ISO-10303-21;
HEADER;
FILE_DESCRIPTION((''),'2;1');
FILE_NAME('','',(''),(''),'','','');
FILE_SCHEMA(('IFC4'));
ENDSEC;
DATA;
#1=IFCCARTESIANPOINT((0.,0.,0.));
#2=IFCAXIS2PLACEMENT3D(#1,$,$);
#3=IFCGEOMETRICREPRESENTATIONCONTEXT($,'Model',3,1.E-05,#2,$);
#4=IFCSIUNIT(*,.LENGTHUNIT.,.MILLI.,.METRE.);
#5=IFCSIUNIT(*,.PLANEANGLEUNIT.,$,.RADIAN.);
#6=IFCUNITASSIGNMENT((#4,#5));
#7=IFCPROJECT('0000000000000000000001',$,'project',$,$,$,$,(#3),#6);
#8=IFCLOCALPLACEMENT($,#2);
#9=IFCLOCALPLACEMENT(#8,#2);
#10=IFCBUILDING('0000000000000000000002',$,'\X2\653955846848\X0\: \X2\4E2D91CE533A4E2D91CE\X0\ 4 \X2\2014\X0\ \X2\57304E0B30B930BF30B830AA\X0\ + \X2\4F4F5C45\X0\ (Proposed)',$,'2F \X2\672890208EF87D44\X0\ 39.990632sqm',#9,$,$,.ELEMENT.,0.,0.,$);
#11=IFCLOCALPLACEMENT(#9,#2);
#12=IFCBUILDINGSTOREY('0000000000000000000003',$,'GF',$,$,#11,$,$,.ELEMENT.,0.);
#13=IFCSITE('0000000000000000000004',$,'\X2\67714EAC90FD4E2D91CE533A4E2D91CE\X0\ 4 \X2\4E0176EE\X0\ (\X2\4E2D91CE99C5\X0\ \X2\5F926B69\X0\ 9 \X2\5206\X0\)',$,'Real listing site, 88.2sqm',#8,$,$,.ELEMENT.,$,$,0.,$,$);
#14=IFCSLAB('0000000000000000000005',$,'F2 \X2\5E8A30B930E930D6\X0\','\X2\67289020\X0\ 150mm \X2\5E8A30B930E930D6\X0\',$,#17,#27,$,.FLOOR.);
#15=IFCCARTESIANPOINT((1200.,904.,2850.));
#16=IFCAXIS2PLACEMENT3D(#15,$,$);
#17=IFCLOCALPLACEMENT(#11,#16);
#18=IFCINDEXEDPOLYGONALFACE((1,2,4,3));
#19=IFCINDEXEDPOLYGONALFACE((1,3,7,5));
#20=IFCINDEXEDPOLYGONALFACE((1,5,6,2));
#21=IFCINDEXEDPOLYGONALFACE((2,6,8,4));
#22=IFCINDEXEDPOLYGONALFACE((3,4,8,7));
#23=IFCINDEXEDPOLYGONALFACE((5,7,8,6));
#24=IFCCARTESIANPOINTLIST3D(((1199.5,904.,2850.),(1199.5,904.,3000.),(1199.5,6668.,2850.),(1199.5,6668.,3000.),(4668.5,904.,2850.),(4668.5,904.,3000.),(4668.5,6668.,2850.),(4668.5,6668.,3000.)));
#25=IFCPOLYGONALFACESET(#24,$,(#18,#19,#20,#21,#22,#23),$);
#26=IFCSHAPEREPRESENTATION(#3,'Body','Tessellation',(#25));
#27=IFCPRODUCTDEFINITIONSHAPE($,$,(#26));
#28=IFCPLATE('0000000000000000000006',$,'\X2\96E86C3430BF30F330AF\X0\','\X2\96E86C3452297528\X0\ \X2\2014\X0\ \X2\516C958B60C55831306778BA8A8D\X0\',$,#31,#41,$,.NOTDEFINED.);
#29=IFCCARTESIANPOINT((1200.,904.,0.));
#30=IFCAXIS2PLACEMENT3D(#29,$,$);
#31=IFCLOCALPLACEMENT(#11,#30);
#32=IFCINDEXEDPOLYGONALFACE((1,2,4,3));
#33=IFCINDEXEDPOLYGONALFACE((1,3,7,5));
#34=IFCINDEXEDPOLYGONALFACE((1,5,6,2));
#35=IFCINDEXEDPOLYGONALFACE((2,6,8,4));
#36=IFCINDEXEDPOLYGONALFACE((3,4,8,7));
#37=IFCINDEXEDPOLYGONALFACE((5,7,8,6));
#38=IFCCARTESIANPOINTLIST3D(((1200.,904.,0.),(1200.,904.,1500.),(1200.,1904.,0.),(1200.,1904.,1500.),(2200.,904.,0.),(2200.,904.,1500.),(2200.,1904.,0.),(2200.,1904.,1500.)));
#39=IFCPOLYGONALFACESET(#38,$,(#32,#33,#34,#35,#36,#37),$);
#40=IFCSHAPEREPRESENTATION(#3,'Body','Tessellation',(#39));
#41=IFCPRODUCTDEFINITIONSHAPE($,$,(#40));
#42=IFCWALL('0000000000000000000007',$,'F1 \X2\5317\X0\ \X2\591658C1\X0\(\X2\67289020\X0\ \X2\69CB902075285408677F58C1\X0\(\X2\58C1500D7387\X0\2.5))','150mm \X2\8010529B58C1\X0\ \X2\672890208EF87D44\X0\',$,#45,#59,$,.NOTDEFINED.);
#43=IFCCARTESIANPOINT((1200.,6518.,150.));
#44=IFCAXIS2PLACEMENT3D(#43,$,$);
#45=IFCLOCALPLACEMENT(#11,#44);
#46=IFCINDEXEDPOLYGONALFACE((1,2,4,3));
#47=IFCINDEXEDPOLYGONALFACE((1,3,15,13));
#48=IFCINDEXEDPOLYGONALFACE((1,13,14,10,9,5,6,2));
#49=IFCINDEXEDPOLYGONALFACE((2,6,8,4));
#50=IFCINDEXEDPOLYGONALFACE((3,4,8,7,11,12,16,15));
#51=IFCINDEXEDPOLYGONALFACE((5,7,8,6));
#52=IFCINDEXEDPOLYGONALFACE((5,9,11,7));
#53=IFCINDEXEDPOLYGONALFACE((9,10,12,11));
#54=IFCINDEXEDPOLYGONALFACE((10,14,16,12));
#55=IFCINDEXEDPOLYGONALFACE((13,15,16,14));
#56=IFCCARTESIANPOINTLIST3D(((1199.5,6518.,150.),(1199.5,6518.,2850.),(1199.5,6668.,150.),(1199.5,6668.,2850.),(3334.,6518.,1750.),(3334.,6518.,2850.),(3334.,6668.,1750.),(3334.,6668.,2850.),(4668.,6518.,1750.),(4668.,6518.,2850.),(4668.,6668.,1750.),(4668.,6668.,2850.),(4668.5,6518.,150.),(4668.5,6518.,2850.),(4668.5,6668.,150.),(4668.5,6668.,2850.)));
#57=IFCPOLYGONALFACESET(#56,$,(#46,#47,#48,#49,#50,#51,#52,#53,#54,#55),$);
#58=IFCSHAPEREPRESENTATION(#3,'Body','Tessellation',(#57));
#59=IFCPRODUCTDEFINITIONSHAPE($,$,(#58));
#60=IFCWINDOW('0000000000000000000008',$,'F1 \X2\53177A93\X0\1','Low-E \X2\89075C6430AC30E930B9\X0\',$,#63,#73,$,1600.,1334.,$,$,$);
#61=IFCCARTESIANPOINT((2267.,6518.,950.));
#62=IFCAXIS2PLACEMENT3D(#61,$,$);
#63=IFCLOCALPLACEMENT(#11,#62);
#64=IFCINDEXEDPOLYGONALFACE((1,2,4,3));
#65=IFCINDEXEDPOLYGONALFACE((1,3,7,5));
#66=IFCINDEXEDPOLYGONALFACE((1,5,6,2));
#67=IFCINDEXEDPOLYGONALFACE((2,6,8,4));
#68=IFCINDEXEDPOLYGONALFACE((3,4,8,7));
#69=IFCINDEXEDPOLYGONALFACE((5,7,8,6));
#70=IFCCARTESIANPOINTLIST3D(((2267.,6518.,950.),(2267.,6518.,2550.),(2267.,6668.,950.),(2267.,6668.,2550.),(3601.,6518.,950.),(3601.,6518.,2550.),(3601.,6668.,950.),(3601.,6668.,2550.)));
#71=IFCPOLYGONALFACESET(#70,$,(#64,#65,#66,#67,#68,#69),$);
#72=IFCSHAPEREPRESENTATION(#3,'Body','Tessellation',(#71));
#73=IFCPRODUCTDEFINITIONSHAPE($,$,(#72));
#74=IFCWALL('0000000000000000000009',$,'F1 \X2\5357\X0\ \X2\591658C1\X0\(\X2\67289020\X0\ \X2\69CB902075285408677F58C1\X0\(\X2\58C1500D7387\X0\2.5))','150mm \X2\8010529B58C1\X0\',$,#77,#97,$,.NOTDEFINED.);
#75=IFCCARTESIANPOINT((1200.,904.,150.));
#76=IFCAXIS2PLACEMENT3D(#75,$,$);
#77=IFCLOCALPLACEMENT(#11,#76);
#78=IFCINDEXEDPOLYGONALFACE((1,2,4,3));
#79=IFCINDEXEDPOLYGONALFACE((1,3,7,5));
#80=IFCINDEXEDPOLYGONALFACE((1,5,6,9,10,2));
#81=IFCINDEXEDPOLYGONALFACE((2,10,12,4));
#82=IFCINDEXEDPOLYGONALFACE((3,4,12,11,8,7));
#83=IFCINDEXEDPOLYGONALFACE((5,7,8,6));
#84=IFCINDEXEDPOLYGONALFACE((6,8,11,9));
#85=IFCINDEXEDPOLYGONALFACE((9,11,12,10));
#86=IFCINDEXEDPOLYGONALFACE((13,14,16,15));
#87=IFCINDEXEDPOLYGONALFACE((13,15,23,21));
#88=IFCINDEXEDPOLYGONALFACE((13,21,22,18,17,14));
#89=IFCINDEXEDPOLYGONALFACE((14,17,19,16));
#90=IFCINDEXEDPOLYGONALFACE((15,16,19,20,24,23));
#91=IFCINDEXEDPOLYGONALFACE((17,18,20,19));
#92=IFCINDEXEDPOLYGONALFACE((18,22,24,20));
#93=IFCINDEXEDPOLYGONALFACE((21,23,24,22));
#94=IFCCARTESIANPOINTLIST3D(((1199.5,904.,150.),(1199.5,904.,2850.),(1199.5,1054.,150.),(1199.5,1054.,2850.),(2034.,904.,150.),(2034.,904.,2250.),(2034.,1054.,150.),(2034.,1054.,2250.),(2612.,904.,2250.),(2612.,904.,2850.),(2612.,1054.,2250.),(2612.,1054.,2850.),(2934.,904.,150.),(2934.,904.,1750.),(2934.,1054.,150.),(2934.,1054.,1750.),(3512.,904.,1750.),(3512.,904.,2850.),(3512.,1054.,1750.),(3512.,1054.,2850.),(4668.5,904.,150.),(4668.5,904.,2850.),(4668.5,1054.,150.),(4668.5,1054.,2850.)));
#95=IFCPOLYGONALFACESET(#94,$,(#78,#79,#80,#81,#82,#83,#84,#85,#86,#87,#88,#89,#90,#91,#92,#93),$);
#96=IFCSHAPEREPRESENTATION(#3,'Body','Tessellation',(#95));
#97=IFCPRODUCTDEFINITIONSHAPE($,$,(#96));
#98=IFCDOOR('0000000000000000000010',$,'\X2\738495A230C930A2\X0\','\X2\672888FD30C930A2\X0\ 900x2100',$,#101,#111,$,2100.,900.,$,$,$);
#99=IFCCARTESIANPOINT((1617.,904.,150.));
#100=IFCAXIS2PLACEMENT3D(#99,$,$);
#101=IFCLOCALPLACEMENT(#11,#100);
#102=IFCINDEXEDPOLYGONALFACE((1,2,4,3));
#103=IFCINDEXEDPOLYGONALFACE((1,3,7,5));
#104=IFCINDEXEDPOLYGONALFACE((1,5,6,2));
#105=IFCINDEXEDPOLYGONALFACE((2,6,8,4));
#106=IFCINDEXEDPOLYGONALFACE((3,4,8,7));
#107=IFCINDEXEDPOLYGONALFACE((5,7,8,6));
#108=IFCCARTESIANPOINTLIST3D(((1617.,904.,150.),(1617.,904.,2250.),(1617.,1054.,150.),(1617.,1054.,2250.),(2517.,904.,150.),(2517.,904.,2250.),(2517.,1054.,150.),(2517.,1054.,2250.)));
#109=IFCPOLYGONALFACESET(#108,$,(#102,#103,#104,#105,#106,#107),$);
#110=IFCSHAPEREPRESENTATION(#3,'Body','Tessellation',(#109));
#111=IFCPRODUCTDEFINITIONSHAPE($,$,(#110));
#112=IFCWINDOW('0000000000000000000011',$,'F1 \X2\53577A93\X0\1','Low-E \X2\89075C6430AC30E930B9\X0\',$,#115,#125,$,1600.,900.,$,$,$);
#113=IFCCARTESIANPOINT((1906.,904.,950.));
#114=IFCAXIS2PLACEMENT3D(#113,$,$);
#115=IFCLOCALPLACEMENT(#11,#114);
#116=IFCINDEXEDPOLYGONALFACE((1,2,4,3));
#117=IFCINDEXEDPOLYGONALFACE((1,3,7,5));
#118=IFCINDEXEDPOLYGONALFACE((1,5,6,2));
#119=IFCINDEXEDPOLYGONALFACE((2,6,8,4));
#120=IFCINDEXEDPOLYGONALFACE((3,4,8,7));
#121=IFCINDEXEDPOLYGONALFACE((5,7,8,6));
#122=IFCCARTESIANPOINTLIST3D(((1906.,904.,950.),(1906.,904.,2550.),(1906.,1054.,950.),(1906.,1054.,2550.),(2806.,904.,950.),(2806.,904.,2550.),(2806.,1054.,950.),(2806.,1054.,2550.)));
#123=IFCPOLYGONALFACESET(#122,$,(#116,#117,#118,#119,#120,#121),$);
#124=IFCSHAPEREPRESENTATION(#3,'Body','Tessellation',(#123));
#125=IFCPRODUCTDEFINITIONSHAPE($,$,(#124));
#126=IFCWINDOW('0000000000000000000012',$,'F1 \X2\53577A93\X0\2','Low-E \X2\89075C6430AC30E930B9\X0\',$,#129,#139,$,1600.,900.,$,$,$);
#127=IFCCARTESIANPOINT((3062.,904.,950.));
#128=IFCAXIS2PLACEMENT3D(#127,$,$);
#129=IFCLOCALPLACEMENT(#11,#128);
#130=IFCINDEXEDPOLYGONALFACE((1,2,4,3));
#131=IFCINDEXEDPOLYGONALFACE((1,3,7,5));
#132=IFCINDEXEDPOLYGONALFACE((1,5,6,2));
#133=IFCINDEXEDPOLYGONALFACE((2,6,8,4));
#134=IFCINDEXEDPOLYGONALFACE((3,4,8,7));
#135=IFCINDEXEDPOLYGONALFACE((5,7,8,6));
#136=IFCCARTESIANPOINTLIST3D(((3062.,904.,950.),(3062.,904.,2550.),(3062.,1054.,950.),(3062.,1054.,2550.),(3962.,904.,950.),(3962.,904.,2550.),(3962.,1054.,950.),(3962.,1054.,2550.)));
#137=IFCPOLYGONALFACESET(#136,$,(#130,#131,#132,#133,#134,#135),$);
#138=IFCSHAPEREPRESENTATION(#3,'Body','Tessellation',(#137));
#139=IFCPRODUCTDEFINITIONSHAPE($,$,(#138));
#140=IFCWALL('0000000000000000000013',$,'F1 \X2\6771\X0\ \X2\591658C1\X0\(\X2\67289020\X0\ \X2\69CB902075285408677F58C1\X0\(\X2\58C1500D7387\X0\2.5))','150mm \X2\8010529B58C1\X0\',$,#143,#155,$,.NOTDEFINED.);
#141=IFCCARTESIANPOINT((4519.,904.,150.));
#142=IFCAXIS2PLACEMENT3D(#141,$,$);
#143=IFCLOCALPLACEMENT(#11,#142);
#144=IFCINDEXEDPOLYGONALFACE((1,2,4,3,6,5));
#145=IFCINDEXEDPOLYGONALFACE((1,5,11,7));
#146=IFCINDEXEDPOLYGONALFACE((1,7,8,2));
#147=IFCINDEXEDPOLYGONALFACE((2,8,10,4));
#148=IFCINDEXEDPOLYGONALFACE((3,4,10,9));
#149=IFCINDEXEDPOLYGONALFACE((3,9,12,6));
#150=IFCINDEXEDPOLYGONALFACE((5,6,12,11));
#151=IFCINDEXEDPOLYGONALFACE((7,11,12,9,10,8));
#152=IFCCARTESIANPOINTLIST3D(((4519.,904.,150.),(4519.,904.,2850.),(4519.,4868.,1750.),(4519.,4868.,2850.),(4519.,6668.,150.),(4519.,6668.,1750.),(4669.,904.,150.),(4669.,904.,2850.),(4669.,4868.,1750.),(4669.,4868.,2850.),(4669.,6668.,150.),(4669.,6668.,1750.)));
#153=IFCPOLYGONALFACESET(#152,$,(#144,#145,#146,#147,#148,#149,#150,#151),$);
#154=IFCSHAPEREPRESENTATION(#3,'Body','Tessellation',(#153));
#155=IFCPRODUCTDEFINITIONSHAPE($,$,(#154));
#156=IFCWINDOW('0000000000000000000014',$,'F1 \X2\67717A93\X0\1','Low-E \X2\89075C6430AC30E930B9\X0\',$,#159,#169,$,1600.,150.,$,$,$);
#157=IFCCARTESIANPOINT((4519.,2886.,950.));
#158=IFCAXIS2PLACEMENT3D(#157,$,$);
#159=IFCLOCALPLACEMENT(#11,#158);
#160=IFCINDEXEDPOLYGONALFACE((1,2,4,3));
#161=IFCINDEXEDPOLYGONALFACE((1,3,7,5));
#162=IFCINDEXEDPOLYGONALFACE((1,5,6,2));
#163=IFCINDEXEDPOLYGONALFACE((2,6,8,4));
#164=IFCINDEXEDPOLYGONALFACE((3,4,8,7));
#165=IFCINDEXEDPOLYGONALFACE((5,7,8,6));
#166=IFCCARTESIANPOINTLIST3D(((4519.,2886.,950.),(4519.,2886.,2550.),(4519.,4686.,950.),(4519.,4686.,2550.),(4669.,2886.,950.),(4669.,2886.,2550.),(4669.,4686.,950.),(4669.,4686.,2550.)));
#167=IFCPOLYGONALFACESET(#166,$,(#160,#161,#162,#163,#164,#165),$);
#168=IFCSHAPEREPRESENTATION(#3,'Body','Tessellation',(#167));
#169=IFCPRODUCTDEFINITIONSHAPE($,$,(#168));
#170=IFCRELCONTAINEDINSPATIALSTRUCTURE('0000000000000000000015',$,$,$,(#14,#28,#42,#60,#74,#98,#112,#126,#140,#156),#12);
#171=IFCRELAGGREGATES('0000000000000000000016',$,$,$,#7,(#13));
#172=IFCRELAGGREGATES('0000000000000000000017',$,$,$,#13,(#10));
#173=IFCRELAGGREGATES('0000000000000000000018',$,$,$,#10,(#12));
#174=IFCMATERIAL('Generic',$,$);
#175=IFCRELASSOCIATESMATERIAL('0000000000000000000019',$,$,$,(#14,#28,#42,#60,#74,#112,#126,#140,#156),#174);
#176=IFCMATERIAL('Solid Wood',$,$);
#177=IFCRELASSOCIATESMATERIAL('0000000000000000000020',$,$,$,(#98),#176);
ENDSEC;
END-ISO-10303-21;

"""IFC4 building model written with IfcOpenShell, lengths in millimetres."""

from ifc_helpers import new_model, si_unit, frame, frame_2d, origin, place, context, project, spatial, rectangle, extrude, material, element, fill, save


model = new_model("IFC4")

# Units and contexts
model_context = context("Model", 3, precision=1e-05, world=origin())
ifc_project = project(units=[si_unit("LENGTHUNIT", "METRE", prefix="MILLI"), si_unit("PLANEANGLEUNIT", "RADIAN")], contexts=[model_context])

# Site, building, storey
site_placement = place(None, origin())
site = spatial("IfcSite", under=ifc_project, at=site_placement, Name="東京都中野区中野 4 丁目 (中野駅 徒歩 9 分)", ObjectType="Real listing site, 88.2sqm", CompositionType="ELEMENT", RefElevation=0.0)
building_placement = place(site_placement, origin())
building = spatial("IfcBuilding", under=site, at=building_placement, Name="改善案: 中野区中野 4 — 地下スタジオ + 住居 (Proposed)", ObjectType="2F 木造軸組 39.990632sqm", CompositionType="ELEMENT", ElevationOfRefHeight=0.0, ElevationOfTerrain=0.0)
storey_placement = place(building_placement, origin())
storey = spatial("IfcBuildingStorey", under=building, at=storey_placement, Name="GF", CompositionType="ELEMENT", Elevation=0.0)

# Slab
ifc_material_1 = material(Name="Generic")
slab_1_placement = place(storey_placement, frame((1200.0, 904.0, 2850.0)))
element("IfcSlab", 1, at=slab_1_placement, inside=storey, material=ifc_material_1, Name="F2 床スラブ", Description="木造 150mm 床スラブ", PredefinedType="FLOOR", context=model_context, shape_type="SweptSolid", body=[
    extrude(rectangle(XDim=3469.0, YDim=5764.0, at=frame_2d((1734.0, 2882.0))), frame((1200.0, 904.0, 2850.0)), (0.0, 0.0, 1.0), 150.0),
])

# Plate
plate_placement = place(storey_placement, frame((1200.0, 904.0, 0.0)))
element("IfcPlate", 2, at=plate_placement, inside=storey, material=ifc_material_1, Name="雨水タンク", Description="雨水利用 — 公開情報で確認", PredefinedType="NOTDEFINED", context=model_context, shape_type="SweptSolid", body=[
    extrude(rectangle(XDim=1000.0, YDim=1000.0, at=frame_2d((500.0, 500.0))), frame((1200.0, 904.0, 0.0)), (0.0, 0.0, 1.0), 1500.0),
])

# Wall, opening, window
wall_1_placement = place(storey_placement, frame((1200.0, 6518.0, 150.0)))
wall_1 = element("IfcWall", 3, at=wall_1_placement, inside=storey, material=ifc_material_1, Name="F1 北 外壁(木造 構造用合板壁(壁倍率2.5))", Description="150mm 耐力壁 木造軸組", PredefinedType="NOTDEFINED", context=model_context, shape_type="SweptSolid", body=[
    extrude(rectangle(XDim=3469.0, YDim=150.0, at=frame_2d((1734.0, 75.0))), frame((1200.0, 6518.0, 150.0)), (0.0, 0.0, 1.0), 2700.0),
])
opening_1_placement = place(storey_placement, frame((2267.0, 6518.0, 950.0)))
opening_1 = element("IfcOpeningElement", 4, at=opening_1_placement, cuts=wall_1, PredefinedType="NOTDEFINED", context=model_context, shape_type="SweptSolid", body=[
    extrude(rectangle(XDim=1334.0, YDim=150.0, at=frame_2d((667.0, 75.0))), frame((2267.0, 6518.0, 950.0)), (0.0, 0.0, 1.0), 1600.0),
])
window_1_placement = place(storey_placement, frame((2267.0, 6518.0, 950.0)))
window_1 = element("IfcWindow", 5, at=window_1_placement, inside=storey, material=ifc_material_1, Name="F1 北窓1", Description="Low-E 複層ガラス", OverallHeight=1600.0, OverallWidth=1334.0, context=model_context, shape_type="SweptSolid", body=[
    extrude(rectangle(XDim=1334.0, YDim=150.0, at=frame_2d((667.0, 75.0))), frame((2267.0, 6518.0, 950.0)), (0.0, 0.0, 1.0), 1600.0),
])
fill(opening_1, window_1)

# Wall, openings, door, windows
wall_2_placement = place(storey_placement, frame((1200.0, 904.0, 150.0)))
wall_2 = element("IfcWall", 6, at=wall_2_placement, inside=storey, material=ifc_material_1, Name="F1 南 外壁(木造 構造用合板壁(壁倍率2.5))", Description="150mm 耐力壁", PredefinedType="NOTDEFINED", context=model_context, shape_type="SweptSolid", body=[
    extrude(rectangle(XDim=3469.0, YDim=150.0, at=frame_2d((1734.0, 75.0))), frame((1200.0, 904.0, 150.0)), (0.0, 0.0, 1.0), 2700.0),
])
opening_2_placement = place(storey_placement, frame((1617.0, 904.0, 150.0)))
opening_2 = element("IfcOpeningElement", 7, at=opening_2_placement, cuts=wall_2, PredefinedType="NOTDEFINED", context=model_context, shape_type="SweptSolid", body=[
    extrude(rectangle(XDim=900.0, YDim=150.0, at=frame_2d((450.0, 75.0))), frame((1617.0, 904.0, 150.0)), (0.0, 0.0, 1.0), 2100.0),
])
opening_3_placement = place(storey_placement, frame((1906.0, 904.0, 950.0)))
opening_3 = element("IfcOpeningElement", 8, at=opening_3_placement, cuts=wall_2, PredefinedType="NOTDEFINED", context=model_context, shape_type="SweptSolid", body=[
    extrude(rectangle(XDim=900.0, YDim=150.0, at=frame_2d((450.0, 75.0))), frame((1906.0, 904.0, 950.0)), (0.0, 0.0, 1.0), 1600.0),
])
opening_4_placement = place(storey_placement, frame((3062.0, 904.0, 950.0)))
opening_4 = element("IfcOpeningElement", 9, at=opening_4_placement, cuts=wall_2, PredefinedType="NOTDEFINED", context=model_context, shape_type="SweptSolid", body=[
    extrude(rectangle(XDim=900.0, YDim=150.0, at=frame_2d((450.0, 75.0))), frame((3062.0, 904.0, 950.0)), (0.0, 0.0, 1.0), 1600.0),
])
ifc_material_2 = material(Name="Solid Wood")
door_placement = place(storey_placement, frame((1617.0, 904.0, 150.0)))
door = element("IfcDoor", 10, at=door_placement, inside=storey, material=ifc_material_2, Name="玄関ドア", Description="木製ドア 900x2100", OverallHeight=2100.0, OverallWidth=900.0, context=model_context, shape_type="SweptSolid", body=[
    extrude(rectangle(XDim=900.0, YDim=150.0, at=frame_2d((450.0, 75.0))), frame((1617.0, 904.0, 150.0)), (0.0, 0.0, 1.0), 2100.0),
])
fill(opening_2, door)
window_2_placement = place(storey_placement, frame((1906.0, 904.0, 950.0)))
window_2 = element("IfcWindow", 11, at=window_2_placement, inside=storey, material=ifc_material_1, Name="F1 南窓1", Description="Low-E 複層ガラス", OverallHeight=1600.0, OverallWidth=900.0, context=model_context, shape_type="SweptSolid", body=[
    extrude(rectangle(XDim=900.0, YDim=150.0, at=frame_2d((450.0, 75.0))), frame((1906.0, 904.0, 950.0)), (0.0, 0.0, 1.0), 1600.0),
])
fill(opening_3, window_2)
window_3_placement = place(storey_placement, frame((3062.0, 904.0, 950.0)))
window_3 = element("IfcWindow", 12, at=window_3_placement, inside=storey, material=ifc_material_1, Name="F1 南窓2", Description="Low-E 複層ガラス", OverallHeight=1600.0, OverallWidth=900.0, context=model_context, shape_type="SweptSolid", body=[
    extrude(rectangle(XDim=900.0, YDim=150.0, at=frame_2d((450.0, 75.0))), frame((3062.0, 904.0, 950.0)), (0.0, 0.0, 1.0), 1600.0),
])
fill(opening_4, window_3)

# Wall, opening, window
wall_3_placement = place(storey_placement, frame((4519.0, 904.0, 150.0)))
wall_3 = element("IfcWall", 13, at=wall_3_placement, inside=storey, material=ifc_material_1, Name="F1 東 外壁(木造 構造用合板壁(壁倍率2.5))", Description="150mm 耐力壁", PredefinedType="NOTDEFINED", context=model_context, shape_type="SweptSolid", body=[
    extrude(rectangle(XDim=150.0, YDim=5764.0, at=frame_2d((75.0, 2882.0))), frame((4519.0, 904.0, 150.0)), (0.0, 0.0, 1.0), 2700.0),
])
opening_5_placement = place(storey_placement, frame((4519.0, 2886.0, 950.0)))
opening_5 = element("IfcOpeningElement", 14, at=opening_5_placement, cuts=wall_3, PredefinedType="NOTDEFINED", context=model_context, shape_type="SweptSolid", body=[
    extrude(rectangle(XDim=150.0, YDim=1800.0, at=frame_2d((75.0, 900.0))), frame((4519.0, 2886.0, 950.0)), (0.0, 0.0, 1.0), 1600.0),
])
window_4_placement = place(storey_placement, frame((4519.0, 2886.0, 950.0)))
window_4 = element("IfcWindow", 15, at=window_4_placement, inside=storey, material=ifc_material_1, Name="F1 東窓1", Description="Low-E 複層ガラス", OverallHeight=1600.0, OverallWidth=150.0, context=model_context, shape_type="SweptSolid", body=[
    extrude(rectangle(XDim=150.0, YDim=1800.0, at=frame_2d((75.0, 900.0))), frame((4519.0, 2886.0, 950.0)), (0.0, 0.0, 1.0), 1600.0),
])
fill(opening_5, window_4)

save(model, "model.ifc")
